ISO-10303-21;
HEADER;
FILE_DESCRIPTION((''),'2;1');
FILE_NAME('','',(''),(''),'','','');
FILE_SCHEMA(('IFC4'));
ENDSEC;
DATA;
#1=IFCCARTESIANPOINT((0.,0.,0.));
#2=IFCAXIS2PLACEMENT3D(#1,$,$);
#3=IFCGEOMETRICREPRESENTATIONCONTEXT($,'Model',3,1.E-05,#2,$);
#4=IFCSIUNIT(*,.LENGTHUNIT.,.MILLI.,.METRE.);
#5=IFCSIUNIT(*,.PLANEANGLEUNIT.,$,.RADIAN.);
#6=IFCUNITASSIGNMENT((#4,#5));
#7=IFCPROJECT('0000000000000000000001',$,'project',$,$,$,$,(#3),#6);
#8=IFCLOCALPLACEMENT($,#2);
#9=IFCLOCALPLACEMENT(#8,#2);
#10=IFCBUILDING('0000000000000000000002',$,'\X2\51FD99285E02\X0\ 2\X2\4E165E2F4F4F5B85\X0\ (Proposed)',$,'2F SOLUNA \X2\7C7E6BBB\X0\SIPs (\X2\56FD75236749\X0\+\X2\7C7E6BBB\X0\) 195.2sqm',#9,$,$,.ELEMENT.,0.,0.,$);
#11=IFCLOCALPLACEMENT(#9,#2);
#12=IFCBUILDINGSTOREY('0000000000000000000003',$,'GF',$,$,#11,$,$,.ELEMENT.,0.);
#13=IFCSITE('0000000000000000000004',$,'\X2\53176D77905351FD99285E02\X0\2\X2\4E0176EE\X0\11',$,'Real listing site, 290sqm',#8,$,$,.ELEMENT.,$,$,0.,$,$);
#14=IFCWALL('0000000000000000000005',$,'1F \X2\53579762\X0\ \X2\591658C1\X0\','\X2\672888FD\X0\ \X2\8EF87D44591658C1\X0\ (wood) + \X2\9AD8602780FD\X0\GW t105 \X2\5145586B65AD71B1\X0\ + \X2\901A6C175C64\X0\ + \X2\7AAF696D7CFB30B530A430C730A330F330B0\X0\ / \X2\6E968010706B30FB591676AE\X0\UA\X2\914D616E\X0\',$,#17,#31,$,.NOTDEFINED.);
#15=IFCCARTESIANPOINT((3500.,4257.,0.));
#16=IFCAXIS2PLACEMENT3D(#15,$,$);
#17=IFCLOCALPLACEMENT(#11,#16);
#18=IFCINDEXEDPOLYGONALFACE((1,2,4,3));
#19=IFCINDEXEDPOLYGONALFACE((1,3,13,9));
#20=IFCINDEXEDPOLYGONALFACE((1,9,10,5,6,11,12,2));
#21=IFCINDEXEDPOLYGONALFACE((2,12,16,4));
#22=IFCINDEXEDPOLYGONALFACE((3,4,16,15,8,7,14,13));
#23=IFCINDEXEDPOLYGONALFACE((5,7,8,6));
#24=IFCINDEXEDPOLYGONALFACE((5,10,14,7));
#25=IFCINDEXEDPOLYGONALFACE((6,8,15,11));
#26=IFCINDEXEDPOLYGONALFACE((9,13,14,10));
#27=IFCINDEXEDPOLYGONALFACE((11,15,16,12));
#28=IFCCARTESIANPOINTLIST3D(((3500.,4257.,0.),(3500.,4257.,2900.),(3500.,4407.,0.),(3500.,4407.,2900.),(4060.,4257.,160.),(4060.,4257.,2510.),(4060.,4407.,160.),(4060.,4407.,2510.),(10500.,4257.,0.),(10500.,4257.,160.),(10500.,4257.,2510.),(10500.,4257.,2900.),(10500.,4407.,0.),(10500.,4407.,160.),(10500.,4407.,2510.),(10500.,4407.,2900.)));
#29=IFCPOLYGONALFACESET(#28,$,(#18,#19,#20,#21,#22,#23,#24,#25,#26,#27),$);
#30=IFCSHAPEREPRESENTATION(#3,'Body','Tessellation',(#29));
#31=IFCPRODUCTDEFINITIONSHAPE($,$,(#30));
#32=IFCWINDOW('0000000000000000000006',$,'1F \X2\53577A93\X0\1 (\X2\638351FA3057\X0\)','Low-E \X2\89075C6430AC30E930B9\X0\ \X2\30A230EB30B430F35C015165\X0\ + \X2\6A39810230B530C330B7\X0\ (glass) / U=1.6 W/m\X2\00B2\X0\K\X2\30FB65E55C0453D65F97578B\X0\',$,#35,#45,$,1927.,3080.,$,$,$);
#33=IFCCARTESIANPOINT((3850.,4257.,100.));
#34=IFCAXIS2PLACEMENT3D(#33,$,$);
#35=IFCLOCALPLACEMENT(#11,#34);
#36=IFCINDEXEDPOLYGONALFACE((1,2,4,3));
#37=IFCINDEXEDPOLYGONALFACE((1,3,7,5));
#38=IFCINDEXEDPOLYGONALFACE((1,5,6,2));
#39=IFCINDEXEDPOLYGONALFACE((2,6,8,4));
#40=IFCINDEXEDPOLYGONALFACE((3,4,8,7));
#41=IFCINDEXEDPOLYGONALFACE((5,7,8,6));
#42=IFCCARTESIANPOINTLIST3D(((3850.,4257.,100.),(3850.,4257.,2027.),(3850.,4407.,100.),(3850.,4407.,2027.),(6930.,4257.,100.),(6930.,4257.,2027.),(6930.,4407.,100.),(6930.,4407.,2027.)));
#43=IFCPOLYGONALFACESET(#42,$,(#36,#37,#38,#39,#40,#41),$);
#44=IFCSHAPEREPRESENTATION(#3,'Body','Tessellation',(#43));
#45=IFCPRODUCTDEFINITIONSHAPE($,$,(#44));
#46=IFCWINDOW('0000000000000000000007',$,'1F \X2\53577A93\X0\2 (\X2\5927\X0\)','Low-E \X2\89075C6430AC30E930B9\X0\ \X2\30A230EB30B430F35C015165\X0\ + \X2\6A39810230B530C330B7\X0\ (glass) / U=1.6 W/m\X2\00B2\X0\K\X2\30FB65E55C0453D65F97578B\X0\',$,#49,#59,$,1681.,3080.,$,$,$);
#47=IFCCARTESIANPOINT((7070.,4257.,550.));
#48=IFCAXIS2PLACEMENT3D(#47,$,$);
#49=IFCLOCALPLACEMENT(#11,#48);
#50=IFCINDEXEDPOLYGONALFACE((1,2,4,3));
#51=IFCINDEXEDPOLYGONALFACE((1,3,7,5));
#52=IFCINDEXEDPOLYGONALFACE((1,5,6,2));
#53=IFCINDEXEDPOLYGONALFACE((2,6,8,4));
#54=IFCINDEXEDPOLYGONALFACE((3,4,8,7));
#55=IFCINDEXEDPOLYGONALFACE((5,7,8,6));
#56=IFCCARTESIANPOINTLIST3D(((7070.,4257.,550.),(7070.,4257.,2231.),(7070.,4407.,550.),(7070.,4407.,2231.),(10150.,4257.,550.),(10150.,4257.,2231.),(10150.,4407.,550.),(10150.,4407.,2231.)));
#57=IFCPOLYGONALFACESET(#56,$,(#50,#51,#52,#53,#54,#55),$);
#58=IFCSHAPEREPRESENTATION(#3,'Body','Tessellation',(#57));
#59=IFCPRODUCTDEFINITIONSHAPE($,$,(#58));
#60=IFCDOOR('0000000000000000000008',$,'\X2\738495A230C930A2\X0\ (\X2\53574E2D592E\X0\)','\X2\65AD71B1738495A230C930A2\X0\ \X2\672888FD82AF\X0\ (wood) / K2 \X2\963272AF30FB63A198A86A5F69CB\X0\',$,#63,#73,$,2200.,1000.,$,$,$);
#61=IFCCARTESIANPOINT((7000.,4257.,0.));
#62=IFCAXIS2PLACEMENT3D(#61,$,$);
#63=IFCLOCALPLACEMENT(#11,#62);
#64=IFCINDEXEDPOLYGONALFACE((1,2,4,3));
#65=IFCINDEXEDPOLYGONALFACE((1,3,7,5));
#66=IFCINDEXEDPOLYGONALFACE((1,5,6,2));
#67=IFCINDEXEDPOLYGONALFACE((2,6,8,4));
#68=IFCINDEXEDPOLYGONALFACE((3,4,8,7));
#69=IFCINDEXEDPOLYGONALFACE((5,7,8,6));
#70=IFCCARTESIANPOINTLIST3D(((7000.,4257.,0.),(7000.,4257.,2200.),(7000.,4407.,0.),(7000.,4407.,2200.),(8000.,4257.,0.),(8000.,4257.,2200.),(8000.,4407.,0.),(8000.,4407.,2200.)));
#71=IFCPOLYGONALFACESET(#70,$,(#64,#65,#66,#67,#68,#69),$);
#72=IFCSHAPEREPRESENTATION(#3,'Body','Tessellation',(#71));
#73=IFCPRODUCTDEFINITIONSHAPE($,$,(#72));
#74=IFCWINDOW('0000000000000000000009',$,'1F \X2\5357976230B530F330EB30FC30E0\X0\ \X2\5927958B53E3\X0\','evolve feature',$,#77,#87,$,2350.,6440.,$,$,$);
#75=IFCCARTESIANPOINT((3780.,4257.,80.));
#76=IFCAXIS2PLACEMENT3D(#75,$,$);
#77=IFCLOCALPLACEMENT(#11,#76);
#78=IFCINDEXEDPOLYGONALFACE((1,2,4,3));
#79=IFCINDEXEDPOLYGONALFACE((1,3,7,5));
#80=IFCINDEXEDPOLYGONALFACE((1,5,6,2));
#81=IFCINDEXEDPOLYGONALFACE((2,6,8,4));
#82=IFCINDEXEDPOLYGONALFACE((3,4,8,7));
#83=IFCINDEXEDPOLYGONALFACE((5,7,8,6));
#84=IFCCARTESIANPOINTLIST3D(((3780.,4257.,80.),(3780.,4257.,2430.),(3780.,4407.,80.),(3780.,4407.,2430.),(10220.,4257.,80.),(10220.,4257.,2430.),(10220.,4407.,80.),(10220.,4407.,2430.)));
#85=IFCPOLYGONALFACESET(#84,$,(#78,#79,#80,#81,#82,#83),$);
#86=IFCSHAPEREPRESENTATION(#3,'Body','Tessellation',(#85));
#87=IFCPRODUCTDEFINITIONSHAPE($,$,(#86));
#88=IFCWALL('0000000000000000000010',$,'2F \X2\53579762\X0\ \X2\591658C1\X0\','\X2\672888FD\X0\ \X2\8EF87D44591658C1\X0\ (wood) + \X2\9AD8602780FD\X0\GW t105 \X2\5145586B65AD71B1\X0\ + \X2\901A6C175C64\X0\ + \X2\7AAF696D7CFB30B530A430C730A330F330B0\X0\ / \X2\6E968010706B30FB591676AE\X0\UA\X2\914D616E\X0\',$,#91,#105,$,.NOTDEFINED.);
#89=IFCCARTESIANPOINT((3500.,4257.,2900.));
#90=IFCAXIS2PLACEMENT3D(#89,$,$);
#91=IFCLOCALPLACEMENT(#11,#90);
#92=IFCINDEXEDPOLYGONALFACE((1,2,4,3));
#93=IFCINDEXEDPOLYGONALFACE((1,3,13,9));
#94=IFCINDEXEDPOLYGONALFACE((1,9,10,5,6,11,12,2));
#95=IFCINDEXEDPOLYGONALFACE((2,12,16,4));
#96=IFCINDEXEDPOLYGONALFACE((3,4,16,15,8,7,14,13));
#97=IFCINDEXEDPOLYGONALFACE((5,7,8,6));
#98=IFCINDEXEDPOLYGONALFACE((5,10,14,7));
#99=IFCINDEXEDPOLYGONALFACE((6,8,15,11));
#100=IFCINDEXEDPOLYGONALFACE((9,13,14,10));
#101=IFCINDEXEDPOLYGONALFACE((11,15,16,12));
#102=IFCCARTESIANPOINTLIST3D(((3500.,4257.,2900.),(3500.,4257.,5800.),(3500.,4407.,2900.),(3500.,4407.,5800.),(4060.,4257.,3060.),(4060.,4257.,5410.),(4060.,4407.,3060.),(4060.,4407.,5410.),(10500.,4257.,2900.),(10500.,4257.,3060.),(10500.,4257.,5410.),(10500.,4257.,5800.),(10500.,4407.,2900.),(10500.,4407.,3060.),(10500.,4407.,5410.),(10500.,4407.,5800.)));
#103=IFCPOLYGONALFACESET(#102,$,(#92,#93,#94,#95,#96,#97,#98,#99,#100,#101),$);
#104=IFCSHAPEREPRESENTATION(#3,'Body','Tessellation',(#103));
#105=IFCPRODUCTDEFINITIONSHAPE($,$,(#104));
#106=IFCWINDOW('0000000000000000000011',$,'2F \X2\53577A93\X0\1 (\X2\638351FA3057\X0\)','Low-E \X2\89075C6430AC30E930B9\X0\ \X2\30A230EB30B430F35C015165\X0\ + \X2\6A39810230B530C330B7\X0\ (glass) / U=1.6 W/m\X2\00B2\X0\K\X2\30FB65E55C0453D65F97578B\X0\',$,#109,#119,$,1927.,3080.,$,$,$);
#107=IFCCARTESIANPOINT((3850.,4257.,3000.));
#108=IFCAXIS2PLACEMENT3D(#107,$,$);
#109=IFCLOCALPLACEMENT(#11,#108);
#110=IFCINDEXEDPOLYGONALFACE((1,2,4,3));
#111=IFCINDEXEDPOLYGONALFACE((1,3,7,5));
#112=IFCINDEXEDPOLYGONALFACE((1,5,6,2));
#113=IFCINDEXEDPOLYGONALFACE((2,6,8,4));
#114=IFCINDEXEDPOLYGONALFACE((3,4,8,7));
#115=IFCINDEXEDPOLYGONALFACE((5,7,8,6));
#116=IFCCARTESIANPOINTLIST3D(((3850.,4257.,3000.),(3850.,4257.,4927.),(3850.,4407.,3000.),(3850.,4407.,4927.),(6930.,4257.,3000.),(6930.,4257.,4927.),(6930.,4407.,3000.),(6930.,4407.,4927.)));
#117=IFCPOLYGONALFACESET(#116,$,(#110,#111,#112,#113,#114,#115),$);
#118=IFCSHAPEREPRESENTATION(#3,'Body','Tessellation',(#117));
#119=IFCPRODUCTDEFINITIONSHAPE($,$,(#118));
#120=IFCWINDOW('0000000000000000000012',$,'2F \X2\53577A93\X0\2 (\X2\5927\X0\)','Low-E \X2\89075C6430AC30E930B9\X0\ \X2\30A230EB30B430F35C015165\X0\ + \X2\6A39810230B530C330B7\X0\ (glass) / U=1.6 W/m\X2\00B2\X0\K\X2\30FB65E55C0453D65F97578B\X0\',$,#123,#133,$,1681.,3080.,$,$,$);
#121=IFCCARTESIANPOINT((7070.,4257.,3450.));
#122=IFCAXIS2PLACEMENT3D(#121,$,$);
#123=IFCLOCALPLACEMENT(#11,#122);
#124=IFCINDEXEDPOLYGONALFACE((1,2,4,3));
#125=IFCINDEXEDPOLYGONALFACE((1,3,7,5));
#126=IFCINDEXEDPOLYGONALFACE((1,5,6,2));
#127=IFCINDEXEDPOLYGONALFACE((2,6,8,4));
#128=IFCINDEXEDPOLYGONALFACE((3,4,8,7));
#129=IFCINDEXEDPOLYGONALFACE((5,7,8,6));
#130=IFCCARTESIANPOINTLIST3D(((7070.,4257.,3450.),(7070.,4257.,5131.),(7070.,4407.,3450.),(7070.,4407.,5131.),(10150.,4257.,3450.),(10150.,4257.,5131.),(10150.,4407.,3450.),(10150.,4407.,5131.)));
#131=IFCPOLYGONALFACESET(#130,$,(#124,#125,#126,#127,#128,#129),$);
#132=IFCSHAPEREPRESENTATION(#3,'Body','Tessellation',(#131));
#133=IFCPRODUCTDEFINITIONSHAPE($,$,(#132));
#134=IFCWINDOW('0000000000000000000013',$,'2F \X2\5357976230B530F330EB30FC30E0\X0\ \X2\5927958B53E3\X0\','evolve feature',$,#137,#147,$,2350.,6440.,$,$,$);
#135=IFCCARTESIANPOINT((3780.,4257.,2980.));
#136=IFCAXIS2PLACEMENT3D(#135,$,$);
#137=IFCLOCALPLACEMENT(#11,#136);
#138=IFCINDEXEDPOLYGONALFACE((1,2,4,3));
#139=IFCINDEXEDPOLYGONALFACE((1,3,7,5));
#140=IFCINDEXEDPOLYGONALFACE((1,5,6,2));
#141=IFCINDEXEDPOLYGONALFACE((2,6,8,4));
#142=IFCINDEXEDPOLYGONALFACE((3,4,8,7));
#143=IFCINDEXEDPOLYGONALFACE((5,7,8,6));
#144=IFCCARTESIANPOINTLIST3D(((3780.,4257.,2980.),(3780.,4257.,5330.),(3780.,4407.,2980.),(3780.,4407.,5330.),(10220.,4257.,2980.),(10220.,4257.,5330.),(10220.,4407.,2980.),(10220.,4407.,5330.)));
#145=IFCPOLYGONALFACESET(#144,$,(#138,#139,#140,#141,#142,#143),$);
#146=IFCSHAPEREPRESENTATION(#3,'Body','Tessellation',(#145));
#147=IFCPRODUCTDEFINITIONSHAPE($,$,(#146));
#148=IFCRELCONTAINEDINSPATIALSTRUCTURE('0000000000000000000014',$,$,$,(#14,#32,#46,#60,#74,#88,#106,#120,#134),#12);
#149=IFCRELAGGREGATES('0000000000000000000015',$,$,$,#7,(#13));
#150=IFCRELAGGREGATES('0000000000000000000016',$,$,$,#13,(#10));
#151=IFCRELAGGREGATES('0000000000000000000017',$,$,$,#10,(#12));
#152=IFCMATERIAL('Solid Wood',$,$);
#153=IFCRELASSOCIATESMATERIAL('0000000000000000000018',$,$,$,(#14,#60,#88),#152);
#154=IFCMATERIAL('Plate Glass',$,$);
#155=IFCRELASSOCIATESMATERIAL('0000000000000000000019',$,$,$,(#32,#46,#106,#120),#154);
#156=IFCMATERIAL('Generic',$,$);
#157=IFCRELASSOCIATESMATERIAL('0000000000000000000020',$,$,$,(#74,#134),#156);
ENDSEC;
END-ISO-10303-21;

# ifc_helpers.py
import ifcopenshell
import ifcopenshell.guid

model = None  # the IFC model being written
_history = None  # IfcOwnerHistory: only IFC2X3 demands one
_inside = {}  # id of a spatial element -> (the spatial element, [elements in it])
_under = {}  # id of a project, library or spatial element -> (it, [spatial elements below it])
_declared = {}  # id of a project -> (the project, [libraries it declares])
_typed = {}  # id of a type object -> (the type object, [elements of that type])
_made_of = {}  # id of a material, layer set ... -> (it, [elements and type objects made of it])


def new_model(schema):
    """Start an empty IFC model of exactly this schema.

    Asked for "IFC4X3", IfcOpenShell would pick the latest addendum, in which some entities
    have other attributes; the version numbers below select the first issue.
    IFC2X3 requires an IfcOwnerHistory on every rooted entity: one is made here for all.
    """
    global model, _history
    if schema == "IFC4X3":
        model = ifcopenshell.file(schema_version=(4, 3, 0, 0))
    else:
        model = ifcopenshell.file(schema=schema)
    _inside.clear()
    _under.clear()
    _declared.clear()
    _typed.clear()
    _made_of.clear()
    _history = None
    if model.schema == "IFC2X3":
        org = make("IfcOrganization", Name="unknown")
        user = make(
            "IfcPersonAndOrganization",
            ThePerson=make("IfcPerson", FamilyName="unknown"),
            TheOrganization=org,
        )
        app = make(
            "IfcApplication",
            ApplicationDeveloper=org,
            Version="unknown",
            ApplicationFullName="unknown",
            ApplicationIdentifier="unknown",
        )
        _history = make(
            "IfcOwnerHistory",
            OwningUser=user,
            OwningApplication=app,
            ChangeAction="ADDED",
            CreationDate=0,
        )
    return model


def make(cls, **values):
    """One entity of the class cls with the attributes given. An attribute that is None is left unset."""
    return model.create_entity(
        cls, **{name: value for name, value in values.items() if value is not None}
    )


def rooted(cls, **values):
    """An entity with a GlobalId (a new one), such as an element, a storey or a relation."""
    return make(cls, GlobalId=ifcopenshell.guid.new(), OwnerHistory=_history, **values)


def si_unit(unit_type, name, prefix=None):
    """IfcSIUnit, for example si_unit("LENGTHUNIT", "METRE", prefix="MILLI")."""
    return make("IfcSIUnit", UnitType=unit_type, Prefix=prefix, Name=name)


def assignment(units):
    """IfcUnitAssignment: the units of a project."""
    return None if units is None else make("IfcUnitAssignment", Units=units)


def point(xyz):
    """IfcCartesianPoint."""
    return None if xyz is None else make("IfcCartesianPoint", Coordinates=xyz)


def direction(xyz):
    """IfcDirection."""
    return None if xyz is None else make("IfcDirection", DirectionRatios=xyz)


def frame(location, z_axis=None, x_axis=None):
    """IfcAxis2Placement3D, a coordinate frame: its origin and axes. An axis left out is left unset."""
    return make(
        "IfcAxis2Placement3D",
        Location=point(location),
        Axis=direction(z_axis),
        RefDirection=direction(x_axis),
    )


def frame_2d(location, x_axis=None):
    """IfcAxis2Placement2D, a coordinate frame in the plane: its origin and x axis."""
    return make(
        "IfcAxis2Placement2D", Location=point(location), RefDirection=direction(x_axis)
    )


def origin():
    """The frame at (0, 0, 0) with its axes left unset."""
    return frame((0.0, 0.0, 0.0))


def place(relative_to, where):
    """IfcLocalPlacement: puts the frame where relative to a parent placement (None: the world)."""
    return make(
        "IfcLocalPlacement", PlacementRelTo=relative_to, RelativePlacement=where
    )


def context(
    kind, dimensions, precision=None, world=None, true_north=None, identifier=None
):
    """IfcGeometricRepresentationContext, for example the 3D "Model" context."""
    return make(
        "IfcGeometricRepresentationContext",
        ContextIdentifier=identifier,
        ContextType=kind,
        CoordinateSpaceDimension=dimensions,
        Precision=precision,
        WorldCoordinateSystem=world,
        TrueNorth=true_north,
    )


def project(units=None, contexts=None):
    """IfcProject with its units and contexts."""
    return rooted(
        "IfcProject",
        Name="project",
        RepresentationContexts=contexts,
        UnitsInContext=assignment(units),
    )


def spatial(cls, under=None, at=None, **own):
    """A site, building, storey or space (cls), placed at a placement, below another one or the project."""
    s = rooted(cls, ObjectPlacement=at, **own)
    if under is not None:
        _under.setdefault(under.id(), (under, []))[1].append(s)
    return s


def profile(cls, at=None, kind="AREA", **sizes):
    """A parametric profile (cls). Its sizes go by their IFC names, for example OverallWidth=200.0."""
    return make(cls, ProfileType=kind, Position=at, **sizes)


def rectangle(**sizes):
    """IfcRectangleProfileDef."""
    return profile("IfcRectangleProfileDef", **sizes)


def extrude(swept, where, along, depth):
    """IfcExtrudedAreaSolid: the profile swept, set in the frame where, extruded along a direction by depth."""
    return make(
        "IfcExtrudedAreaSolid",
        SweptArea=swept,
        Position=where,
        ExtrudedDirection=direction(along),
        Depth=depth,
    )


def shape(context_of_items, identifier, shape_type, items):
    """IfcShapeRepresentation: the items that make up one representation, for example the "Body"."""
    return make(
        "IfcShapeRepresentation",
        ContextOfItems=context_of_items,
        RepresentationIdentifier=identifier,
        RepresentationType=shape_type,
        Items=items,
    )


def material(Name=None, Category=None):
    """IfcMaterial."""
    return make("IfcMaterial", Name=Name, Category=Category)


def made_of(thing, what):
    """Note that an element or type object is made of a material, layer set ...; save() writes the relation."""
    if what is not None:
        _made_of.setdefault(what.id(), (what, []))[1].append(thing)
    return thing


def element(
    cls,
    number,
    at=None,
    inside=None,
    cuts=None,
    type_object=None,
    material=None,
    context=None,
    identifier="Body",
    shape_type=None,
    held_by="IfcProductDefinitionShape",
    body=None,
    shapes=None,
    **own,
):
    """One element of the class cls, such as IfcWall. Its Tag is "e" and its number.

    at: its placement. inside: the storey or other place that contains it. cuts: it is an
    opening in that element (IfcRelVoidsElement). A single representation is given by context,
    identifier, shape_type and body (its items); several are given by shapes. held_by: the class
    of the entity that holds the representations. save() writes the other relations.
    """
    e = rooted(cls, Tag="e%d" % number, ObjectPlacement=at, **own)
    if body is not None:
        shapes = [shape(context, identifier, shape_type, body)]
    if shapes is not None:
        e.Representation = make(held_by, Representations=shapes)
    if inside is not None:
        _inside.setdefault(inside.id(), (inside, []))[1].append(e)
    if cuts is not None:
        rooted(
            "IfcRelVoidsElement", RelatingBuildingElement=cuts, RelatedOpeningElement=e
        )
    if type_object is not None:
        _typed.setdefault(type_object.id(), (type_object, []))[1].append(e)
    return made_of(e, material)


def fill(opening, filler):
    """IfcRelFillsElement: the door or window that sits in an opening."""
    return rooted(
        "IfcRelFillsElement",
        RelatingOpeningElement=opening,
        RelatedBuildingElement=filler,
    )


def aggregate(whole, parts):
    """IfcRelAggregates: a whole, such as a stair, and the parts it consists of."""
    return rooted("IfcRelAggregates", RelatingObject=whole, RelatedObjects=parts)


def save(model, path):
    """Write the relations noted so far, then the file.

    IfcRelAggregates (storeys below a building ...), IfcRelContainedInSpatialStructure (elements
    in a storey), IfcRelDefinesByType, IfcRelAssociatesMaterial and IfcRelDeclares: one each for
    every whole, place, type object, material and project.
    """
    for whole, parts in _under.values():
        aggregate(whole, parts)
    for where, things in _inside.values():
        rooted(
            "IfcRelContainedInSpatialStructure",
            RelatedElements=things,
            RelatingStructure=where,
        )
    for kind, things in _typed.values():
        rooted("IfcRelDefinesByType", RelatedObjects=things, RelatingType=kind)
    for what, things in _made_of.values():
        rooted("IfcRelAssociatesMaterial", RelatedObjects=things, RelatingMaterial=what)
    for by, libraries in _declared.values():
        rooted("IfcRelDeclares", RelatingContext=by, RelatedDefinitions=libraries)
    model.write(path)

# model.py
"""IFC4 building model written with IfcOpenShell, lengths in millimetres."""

from ifc_helpers import new_model, si_unit, frame, frame_2d, origin, place, context, project, spatial, rectangle, extrude, material, element, fill, save


model = new_model("IFC4")

# Units and contexts
model_context = context("Model", 3, precision=1e-05, world=origin())
ifc_project = project(units=[si_unit("LENGTHUNIT", "METRE", prefix="MILLI"), si_unit("PLANEANGLEUNIT", "RADIAN")], contexts=[model_context])

# Site, building, storey
site_placement = place(None, origin())
site = spatial("IfcSite", under=ifc_project, at=site_placement, Name="北海道函館市2丁目11", ObjectType="Real listing site, 290sqm", CompositionType="ELEMENT", RefElevation=0.0)
building_placement = place(site_placement, origin())
building = spatial("IfcBuilding", under=site, at=building_placement, Name="函館市 2世帯住宅 (Proposed)", ObjectType="2F SOLUNA 籾殻SIPs (国産杉+籾殻) 195.2sqm", CompositionType="ELEMENT", ElevationOfRefHeight=0.0, ElevationOfTerrain=0.0)
storey_placement = place(building_placement, origin())
storey = spatial("IfcBuildingStorey", under=building, at=storey_placement, Name="GF", CompositionType="ELEMENT", Elevation=0.0)

# Shared definitions
ifc_material_1 = material(Name="Solid Wood")

# Wall, openings, windows, door
wall_1_placement = place(storey_placement, frame((3500.0, 4257.0, 0.0)))
wall_1 = element("IfcWall", 1, at=wall_1_placement, inside=storey, material=ifc_material_1, Name="1F 南面 外壁", Description="木製 軸組外壁 (wood) + 高性能GW t105 充填断熱 + 通気層 + 窯業系サイディング / 準耐火・外皮UA配慮", PredefinedType="NOTDEFINED", context=model_context, shape_type="SweptSolid", body=[
    extrude(rectangle(XDim=7000.0, YDim=150.0, at=frame_2d((3500.0, 75.0))), frame((3500.0, 4257.0, 0.0)), (0.0, 0.0, 1.0), 2900.0),
])
opening_1_placement = place(storey_placement, frame((3850.0, 4257.0, 100.0)))
opening_1 = element("IfcOpeningElement", 2, at=opening_1_placement, cuts=wall_1, PredefinedType="NOTDEFINED", context=model_context, shape_type="SweptSolid", body=[
    extrude(rectangle(XDim=3080.0, YDim=150.0, at=frame_2d((1540.0, 75.0))), frame((3850.0, 4257.0, 100.0)), (0.0, 0.0, 1.0), 1927.0),
])
opening_2_placement = place(storey_placement, frame((7070.0, 4257.0, 550.0)))
opening_2 = element("IfcOpeningElement", 3, at=opening_2_placement, cuts=wall_1, PredefinedType="NOTDEFINED", context=model_context, shape_type="SweptSolid", body=[
    extrude(rectangle(XDim=3080.0, YDim=150.0, at=frame_2d((1540.0, 75.0))), frame((7070.0, 4257.0, 550.0)), (0.0, 0.0, 1.0), 1681.0),
])
opening_3_placement = place(storey_placement, frame((7000.0, 4257.0, 0.0)))
opening_3 = element("IfcOpeningElement", 4, at=opening_3_placement, cuts=wall_1, PredefinedType="NOTDEFINED", context=model_context, shape_type="SweptSolid", body=[
    extrude(rectangle(XDim=1000.0, YDim=150.0, at=frame_2d((500.0, 75.0))), frame((7000.0, 4257.0, 0.0)), (0.0, 0.0, 1.0), 2200.0),
])
opening_4_placement = place(storey_placement, frame((3780.0, 4257.0, 80.0)))
opening_4 = element("IfcOpeningElement", 5, at=opening_4_placement, cuts=wall_1, PredefinedType="NOTDEFINED", context=model_context, shape_type="SweptSolid", body=[
    extrude(rectangle(XDim=6440.0, YDim=150.0, at=frame_2d((3220.0, 75.0))), frame((3780.0, 4257.0, 80.0)), (0.0, 0.0, 1.0), 2350.0),
])
ifc_material_2 = material(Name="Plate Glass")
window_1_placement = place(storey_placement, frame((3850.0, 4257.0, 100.0)))
window_1 = element("IfcWindow", 6, at=window_1_placement, inside=storey, material=ifc_material_2, Name="1F 南窓1 (掃出し)", Description="Low-E 複層ガラス アルゴン封入 + 樹脂サッシ (glass) / U=1.6 W/m²K・日射取得型", OverallHeight=1927.0, OverallWidth=3080.0, context=model_context, shape_type="SweptSolid", body=[
    extrude(rectangle(XDim=3080.0, YDim=150.0, at=frame_2d((1540.0, 75.0))), frame((3850.0, 4257.0, 100.0)), (0.0, 0.0, 1.0), 1927.0),
])
fill(opening_1, window_1)
window_2_placement = place(storey_placement, frame((7070.0, 4257.0, 550.0)))
window_2 = element("IfcWindow", 7, at=window_2_placement, inside=storey, material=ifc_material_2, Name="1F 南窓2 (大)", Description="Low-E 複層ガラス アルゴン封入 + 樹脂サッシ (glass) / U=1.6 W/m²K・日射取得型", OverallHeight=1681.0, OverallWidth=3080.0, context=model_context, shape_type="SweptSolid", body=[
    extrude(rectangle(XDim=3080.0, YDim=150.0, at=frame_2d((1540.0, 75.0))), frame((7070.0, 4257.0, 550.0)), (0.0, 0.0, 1.0), 1681.0),
])
fill(opening_2, window_2)
door_placement = place(storey_placement, frame((7000.0, 4257.0, 0.0)))
door = element("IfcDoor", 8, at=door_placement, inside=storey, material=ifc_material_1, Name="玄関ドア (南中央)", Description="断熱玄関ドア 木製芯 (wood) / K2 防犯・採風機構", OverallHeight=2200.0, OverallWidth=1000.0, context=model_context, shape_type="SweptSolid", body=[
    extrude(rectangle(XDim=1000.0, YDim=150.0, at=frame_2d((500.0, 75.0))), frame((7000.0, 4257.0, 0.0)), (0.0, 0.0, 1.0), 2200.0),
])
fill(opening_3, door)
ifc_material_3 = material(Name="Generic")
window_3_placement = place(storey_placement, frame((3780.0, 4257.0, 80.0)))
window_3 = element("IfcWindow", 9, at=window_3_placement, inside=storey, material=ifc_material_3, Name="1F 南面サンルーム 大開口", Description="evolve feature", OverallHeight=2350.0, OverallWidth=6440.0, context=model_context, shape_type="SweptSolid", body=[
    extrude(rectangle(XDim=6440.0, YDim=150.0, at=frame_2d((3220.0, 75.0))), frame((3780.0, 4257.0, 80.0)), (0.0, 0.0, 1.0), 2350.0),
])
fill(opening_4, window_3)

# Wall, openings, windows
wall_2_placement = place(storey_placement, frame((3500.0, 4257.0, 2900.0)))
wall_2 = element("IfcWall", 10, at=wall_2_placement, inside=storey, material=ifc_material_1, Name="2F 南面 外壁", Description="木製 軸組外壁 (wood) + 高性能GW t105 充填断熱 + 通気層 + 窯業系サイディング / 準耐火・外皮UA配慮", PredefinedType="NOTDEFINED", context=model_context, shape_type="SweptSolid", body=[
    extrude(rectangle(XDim=7000.0, YDim=150.0, at=frame_2d((3500.0, 75.0))), frame((3500.0, 4257.0, 2900.0)), (0.0, 0.0, 1.0), 2900.0),
])
opening_5_placement = place(storey_placement, frame((3850.0, 4257.0, 3000.0)))
opening_5 = element("IfcOpeningElement", 11, at=opening_5_placement, cuts=wall_2, PredefinedType="NOTDEFINED", context=model_context, shape_type="SweptSolid", body=[
    extrude(rectangle(XDim=3080.0, YDim=150.0, at=frame_2d((1540.0, 75.0))), frame((3850.0, 4257.0, 3000.0)), (0.0, 0.0, 1.0), 1927.0),
])
opening_6_placement = place(storey_placement, frame((7070.0, 4257.0, 3450.0)))
opening_6 = element("IfcOpeningElement", 12, at=opening_6_placement, cuts=wall_2, PredefinedType="NOTDEFINED", context=model_context, shape_type="SweptSolid", body=[
    extrude(rectangle(XDim=3080.0, YDim=150.0, at=frame_2d((1540.0, 75.0))), frame((7070.0, 4257.0, 3450.0)), (0.0, 0.0, 1.0), 1681.0),
])
opening_7_placement = place(storey_placement, frame((3780.0, 4257.0, 2980.0)))
opening_7 = element("IfcOpeningElement", 13, at=opening_7_placement, cuts=wall_2, PredefinedType="NOTDEFINED", context=model_context, shape_type="SweptSolid", body=[
    extrude(rectangle(XDim=6440.0, YDim=150.0, at=frame_2d((3220.0, 75.0))), frame((3780.0, 4257.0, 2980.0)), (0.0, 0.0, 1.0), 2350.0),
])
window_4_placement = place(storey_placement, frame((3850.0, 4257.0, 3000.0)))
window_4 = element("IfcWindow", 14, at=window_4_placement, inside=storey, material=ifc_material_2, Name="2F 南窓1 (掃出し)", Description="Low-E 複層ガラス アルゴン封入 + 樹脂サッシ (glass) / U=1.6 W/m²K・日射取得型", OverallHeight=1927.0, OverallWidth=3080.0, context=model_context, shape_type="SweptSolid", body=[
    extrude(rectangle(XDim=3080.0, YDim=150.0, at=frame_2d((1540.0, 75.0))), frame((3850.0, 4257.0, 3000.0)), (0.0, 0.0, 1.0), 1927.0),
])
fill(opening_5, window_4)
window_5_placement = place(storey_placement, frame((7070.0, 4257.0, 3450.0)))
window_5 = element("IfcWindow", 15, at=window_5_placement, inside=storey, material=ifc_material_2, Name="2F 南窓2 (大)", Description="Low-E 複層ガラス アルゴン封入 + 樹脂サッシ (glass) / U=1.6 W/m²K・日射取得型", OverallHeight=1681.0, OverallWidth=3080.0, context=model_context, shape_type="SweptSolid", body=[
    extrude(rectangle(XDim=3080.0, YDim=150.0, at=frame_2d((1540.0, 75.0))), frame((7070.0, 4257.0, 3450.0)), (0.0, 0.0, 1.0), 1681.0),
])
fill(opening_6, window_5)
window_6_placement = place(storey_placement, frame((3780.0, 4257.0, 2980.0)))
window_6 = element("IfcWindow", 16, at=window_6_placement, inside=storey, material=ifc_material_3, Name="2F 南面サンルーム 大開口", Description="evolve feature", OverallHeight=2350.0, OverallWidth=6440.0, context=model_context, shape_type="SweptSolid", body=[
    extrude(rectangle(XDim=6440.0, YDim=150.0, at=frame_2d((3220.0, 75.0))), frame((3780.0, 4257.0, 2980.0)), (0.0, 0.0, 1.0), 2350.0),
])
fill(opening_7, window_6)

save(model, "model.ifc")
